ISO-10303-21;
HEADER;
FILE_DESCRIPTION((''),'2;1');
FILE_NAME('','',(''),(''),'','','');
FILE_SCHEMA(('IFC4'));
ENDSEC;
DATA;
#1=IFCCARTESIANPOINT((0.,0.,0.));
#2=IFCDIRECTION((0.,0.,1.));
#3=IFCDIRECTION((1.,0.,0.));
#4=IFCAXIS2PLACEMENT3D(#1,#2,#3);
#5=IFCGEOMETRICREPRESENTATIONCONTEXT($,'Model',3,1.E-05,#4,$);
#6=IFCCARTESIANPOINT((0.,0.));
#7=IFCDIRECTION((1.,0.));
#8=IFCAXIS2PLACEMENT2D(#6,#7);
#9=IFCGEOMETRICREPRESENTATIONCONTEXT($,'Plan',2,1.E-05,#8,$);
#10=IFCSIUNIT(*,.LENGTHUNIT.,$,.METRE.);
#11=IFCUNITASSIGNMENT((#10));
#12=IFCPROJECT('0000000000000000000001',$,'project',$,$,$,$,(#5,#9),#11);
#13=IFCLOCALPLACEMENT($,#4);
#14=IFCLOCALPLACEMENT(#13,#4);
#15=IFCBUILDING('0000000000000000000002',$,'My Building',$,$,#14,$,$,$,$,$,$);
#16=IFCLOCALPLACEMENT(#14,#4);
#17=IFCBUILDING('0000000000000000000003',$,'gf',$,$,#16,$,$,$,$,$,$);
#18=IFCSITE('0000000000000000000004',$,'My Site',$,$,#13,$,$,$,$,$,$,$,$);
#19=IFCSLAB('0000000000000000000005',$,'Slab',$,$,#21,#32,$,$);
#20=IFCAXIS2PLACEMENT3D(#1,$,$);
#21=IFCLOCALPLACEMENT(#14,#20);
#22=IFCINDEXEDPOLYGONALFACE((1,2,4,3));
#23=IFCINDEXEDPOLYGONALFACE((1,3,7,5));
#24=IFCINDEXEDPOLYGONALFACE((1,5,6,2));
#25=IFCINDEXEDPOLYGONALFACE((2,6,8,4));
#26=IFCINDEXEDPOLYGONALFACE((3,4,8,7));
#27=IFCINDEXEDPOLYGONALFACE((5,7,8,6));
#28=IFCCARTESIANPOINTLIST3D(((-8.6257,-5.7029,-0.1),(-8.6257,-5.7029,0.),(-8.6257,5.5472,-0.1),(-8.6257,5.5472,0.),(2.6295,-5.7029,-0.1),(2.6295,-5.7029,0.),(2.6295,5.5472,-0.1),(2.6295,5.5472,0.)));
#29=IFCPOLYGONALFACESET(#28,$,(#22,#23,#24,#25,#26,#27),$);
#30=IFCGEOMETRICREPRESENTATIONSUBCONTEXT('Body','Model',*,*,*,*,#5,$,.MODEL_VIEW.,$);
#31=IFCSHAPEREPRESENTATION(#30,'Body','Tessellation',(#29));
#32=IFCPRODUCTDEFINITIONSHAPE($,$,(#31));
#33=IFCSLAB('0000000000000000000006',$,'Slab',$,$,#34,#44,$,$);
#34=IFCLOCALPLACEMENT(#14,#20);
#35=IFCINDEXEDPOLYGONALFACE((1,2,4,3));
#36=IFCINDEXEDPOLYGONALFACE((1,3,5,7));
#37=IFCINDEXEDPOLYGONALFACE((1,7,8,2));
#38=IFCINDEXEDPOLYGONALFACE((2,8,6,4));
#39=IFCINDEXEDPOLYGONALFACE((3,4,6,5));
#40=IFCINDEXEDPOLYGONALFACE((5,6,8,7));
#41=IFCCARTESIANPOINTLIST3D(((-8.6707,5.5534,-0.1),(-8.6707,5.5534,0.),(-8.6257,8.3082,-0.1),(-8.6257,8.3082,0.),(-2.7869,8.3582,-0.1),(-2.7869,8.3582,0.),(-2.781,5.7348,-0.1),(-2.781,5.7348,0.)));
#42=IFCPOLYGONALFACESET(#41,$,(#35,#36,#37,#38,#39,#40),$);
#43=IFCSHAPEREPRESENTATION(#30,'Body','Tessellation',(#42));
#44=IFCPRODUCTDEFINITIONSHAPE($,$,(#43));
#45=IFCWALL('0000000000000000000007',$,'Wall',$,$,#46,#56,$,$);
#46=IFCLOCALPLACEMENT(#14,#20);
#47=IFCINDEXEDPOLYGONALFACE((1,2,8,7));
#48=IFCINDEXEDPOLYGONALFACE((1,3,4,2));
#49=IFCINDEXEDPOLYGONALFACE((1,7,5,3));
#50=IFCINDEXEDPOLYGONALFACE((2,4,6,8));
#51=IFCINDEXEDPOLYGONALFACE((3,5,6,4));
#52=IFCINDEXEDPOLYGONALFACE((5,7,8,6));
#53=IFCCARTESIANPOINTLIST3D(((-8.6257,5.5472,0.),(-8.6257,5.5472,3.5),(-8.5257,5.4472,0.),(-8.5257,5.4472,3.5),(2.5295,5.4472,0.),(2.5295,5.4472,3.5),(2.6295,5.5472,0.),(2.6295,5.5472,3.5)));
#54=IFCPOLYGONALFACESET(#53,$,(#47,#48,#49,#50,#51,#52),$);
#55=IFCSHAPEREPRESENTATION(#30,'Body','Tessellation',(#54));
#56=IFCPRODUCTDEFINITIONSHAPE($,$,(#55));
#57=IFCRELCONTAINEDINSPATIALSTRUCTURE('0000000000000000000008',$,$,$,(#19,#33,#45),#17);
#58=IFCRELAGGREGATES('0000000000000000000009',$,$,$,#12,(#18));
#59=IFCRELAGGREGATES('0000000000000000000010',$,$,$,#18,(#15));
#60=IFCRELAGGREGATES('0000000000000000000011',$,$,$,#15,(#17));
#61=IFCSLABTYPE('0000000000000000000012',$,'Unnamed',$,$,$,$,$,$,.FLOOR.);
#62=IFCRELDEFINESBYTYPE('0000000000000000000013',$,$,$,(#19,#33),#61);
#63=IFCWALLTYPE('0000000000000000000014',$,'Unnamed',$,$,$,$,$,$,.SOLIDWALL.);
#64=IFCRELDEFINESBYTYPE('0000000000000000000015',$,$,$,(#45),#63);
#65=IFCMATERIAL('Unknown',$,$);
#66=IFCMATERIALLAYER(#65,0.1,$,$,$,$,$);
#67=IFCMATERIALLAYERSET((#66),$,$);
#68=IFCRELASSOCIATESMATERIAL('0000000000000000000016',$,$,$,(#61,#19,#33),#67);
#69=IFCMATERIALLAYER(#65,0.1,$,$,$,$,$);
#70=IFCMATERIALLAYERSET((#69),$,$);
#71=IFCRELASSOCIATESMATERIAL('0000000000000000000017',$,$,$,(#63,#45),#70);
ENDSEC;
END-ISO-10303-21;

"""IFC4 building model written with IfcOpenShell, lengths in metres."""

from ifc_helpers import new_model, si_unit, frame, origin_with_axes, origin_2d_with_axis, place, context, subcontext, project, spatial, line, indexed_curve, outline, extrude, material, layer, layer_set, layer_usage, type_object, element, save


model = new_model("IFC4")

# Units and contexts
model_context = context("Model", 3, precision=1e-05, world=origin_with_axes())
plan_context = context("Plan", 2, precision=1e-05, world=origin_2d_with_axis())
body_context_1 = subcontext(model_context, "Body", "Model", "MODEL_VIEW")
ifc_project = project(units=[si_unit("LENGTHUNIT", "METRE")], contexts=[model_context, plan_context])

# Site, buildings
site_placement = place(None, origin_with_axes())
site = spatial("IfcSite", under=ifc_project, at=site_placement, Name="My Site")
building_1_placement = place(site_placement, origin_with_axes())
building_1 = spatial("IfcBuilding", under=site, at=building_1_placement, Name="My Building")
building_2_placement = place(building_1_placement, origin_with_axes())
building_2 = spatial("IfcBuilding", under=building_1, at=building_2_placement, Name="gf")

# Shared definitions
ifc_material = material(Name="Unknown")

# Slabs
ifc_layer_1 = layer(ifc_material, 0.1)
ifc_layer_set_1 = layer_set([ifc_layer_1])
ifc_layer_usage_1 = layer_usage(ifc_layer_set_1, "AXIS3", "POSITIVE", -0.1)
slab_type = type_object("IfcSlabType", Name="Unnamed", PredefinedType="FLOOR", material=ifc_layer_set_1)
slab_1_placement = place(building_2_placement, frame((-8.6257, 5.5472, 0.0), z_axis=(0.0, 0.0, 1.0), x_axis=(1.0, 0.0, 0.0)))
element("IfcSlab", 1, at=slab_1_placement, inside=building_2, type_object=slab_type, material=ifc_layer_usage_1, Name="Slab", context=body_context_1, shape_type="SweptSolid", body=[
    extrude(outline(indexed_curve([(0.0, 0.0), (11.2552, 0.0), (11.2552, -11.2502), (0.0, -11.2502), (0.0, 0.0)])), frame((0.0, 0.0, -0.1), z_axis=(0.0, 0.0, 1.0), x_axis=(1.0, 0.0, 0.0)), (0.0, 0.0, 1.0), 0.1),
])
ifc_layer_usage_2 = layer_usage(ifc_layer_set_1, "AXIS3", "POSITIVE", -0.1)
slab_2_placement = place(building_2_placement, frame((-8.6707, 5.5534, 0.0), z_axis=(0.0, 0.0, 1.0), x_axis=(1.0, 0.0, 0.0)))
element("IfcSlab", 2, at=slab_2_placement, inside=building_2, type_object=slab_type, material=ifc_layer_usage_2, Name="Slab", context=body_context_1, shape_type="SweptSolid", body=[
    extrude(outline(indexed_curve([(0.0, 0.0), (0.045, 2.7548), (5.8838, 2.8048), (5.8897, 0.1814), (0.0, 0.0)])), frame((0.0, 0.0, -0.1), z_axis=(0.0, 0.0, 1.0), x_axis=(1.0, 0.0, 0.0)), (0.0, 0.0, 1.0), 0.1),
])

# Shared definitions
ifc_layer_2 = layer(ifc_material, 0.1)
ifc_layer_set_2 = layer_set([ifc_layer_2])
wall_type = type_object("IfcWallType", Name="Unnamed", PredefinedType="SOLIDWALL", material=ifc_layer_set_2)

# Wall
ifc_layer_usage_3 = layer_usage(ifc_layer_set_2, "AXIS2", "POSITIVE", 0.0)
wall_1_placement = place(building_2_placement, frame((2.6295, 5.5472, 0.0), z_axis=(0.0, 0.0, 1.0), x_axis=(-1.0, 0.0, 0.0)))
element("IfcWall", 3, at=wall_1_placement, inside=building_2, type_object=wall_type, material=ifc_layer_usage_3, Name="Wall", context=body_context_1, shape_type="SweptSolid", body=[
    extrude(outline(indexed_curve([(0.0, 0.0), (0.1, 0.1), (11.1552, 0.1), (11.2552, 0.0)], segments=[line(1, 2, 3, 4, 1)])), origin_with_axes(), (0.0, 0.0, 1.0), 3.5),
])

save(model, "model.ifc")
